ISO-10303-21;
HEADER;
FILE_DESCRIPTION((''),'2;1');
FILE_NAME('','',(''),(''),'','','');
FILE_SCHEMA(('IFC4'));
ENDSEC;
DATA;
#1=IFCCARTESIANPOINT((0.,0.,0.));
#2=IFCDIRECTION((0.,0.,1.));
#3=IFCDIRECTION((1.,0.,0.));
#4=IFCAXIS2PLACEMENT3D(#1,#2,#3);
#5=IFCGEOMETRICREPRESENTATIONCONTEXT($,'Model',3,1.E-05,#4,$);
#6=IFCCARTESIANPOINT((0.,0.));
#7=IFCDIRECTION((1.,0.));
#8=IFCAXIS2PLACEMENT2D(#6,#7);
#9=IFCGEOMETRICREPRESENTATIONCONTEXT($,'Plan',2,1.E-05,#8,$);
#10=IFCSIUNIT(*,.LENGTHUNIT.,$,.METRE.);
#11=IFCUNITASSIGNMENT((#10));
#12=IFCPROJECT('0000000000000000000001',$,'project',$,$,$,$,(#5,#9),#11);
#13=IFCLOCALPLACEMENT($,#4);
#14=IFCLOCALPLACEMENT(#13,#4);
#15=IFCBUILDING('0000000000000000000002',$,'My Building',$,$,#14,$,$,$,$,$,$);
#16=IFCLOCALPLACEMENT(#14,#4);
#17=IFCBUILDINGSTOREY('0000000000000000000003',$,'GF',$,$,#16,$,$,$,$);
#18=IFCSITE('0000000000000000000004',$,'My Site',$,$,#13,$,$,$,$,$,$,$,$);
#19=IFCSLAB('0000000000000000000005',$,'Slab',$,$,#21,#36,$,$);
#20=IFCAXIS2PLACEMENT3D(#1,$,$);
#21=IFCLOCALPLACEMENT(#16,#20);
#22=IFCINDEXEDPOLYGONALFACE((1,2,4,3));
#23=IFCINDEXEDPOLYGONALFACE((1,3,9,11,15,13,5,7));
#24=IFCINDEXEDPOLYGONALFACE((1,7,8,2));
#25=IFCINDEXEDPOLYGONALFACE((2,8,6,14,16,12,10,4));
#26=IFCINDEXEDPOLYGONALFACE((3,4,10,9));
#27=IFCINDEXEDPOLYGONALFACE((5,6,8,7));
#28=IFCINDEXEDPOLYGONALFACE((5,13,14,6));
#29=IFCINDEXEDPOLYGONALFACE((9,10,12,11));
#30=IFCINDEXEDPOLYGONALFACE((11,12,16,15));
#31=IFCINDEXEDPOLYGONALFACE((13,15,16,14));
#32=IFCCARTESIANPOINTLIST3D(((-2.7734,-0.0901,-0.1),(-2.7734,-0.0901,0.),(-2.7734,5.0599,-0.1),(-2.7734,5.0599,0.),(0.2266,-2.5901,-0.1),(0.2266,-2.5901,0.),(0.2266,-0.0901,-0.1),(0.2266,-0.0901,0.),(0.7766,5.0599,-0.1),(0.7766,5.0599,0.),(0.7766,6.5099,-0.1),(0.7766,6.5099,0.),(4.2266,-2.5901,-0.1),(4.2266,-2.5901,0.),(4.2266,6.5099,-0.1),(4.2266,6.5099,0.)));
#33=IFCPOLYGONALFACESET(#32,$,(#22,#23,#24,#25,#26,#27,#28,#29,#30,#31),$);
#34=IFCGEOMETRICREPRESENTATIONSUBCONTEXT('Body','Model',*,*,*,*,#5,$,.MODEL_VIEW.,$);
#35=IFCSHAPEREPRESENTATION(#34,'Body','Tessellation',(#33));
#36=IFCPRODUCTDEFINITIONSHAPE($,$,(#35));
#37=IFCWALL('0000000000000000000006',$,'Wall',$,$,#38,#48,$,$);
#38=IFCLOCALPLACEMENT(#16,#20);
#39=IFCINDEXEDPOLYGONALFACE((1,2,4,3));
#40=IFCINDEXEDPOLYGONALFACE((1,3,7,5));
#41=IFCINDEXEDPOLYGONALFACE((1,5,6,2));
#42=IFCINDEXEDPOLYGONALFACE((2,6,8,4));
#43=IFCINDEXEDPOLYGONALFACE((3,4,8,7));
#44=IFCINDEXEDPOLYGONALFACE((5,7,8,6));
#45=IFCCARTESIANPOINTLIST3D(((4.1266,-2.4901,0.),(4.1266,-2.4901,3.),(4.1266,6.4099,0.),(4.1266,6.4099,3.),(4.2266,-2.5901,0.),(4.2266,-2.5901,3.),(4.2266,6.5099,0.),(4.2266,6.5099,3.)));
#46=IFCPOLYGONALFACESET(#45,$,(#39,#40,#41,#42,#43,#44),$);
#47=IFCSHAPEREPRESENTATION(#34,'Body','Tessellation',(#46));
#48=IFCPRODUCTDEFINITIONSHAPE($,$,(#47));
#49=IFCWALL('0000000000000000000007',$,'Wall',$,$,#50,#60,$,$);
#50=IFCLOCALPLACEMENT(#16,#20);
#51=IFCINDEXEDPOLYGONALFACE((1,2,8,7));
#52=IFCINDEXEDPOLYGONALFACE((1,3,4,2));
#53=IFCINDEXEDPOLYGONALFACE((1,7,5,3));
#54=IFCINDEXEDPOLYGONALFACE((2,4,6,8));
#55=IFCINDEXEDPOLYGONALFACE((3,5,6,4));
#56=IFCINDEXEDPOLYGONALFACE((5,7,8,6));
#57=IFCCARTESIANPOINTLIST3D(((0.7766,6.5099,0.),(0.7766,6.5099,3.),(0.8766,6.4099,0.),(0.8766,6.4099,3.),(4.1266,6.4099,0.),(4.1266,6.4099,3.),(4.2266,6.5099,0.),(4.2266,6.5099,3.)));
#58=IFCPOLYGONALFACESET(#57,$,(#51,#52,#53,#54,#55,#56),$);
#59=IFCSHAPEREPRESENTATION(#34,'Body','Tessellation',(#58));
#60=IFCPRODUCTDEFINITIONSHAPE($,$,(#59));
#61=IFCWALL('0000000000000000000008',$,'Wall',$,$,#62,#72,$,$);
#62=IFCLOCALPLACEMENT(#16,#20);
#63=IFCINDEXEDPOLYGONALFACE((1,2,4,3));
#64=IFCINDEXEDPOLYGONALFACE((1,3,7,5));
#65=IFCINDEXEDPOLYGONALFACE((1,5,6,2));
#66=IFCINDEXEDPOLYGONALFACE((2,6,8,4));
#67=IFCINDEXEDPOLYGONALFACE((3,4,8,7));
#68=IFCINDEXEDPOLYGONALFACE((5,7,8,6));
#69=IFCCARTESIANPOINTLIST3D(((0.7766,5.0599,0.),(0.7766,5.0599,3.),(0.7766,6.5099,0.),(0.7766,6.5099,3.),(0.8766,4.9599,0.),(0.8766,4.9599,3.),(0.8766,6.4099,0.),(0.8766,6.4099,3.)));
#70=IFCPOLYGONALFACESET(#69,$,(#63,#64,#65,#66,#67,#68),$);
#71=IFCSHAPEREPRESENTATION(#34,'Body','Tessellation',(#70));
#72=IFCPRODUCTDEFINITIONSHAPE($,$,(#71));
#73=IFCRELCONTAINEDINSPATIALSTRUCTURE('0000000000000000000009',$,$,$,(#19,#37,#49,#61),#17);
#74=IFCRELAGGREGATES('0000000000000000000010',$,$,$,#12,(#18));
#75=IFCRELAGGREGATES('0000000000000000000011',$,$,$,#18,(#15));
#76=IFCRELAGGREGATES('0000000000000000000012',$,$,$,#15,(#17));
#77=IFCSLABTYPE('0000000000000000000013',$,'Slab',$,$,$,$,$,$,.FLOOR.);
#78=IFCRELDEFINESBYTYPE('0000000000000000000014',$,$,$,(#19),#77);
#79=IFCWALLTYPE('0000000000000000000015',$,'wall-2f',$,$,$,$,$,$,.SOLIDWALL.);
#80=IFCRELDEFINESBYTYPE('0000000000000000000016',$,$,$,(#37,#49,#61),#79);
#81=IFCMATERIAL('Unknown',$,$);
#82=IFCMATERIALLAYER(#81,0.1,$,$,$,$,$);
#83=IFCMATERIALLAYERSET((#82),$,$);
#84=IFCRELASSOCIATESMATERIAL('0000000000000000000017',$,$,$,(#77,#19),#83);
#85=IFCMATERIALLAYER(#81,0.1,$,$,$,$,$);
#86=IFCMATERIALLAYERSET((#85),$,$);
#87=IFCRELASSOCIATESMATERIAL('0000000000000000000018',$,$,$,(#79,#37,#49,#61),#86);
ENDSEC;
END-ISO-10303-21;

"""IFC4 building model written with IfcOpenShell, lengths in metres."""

from ifc_helpers import new_model, si_unit, frame, origin_with_axes, origin_2d_with_axis, place, context, subcontext, project, spatial, line, indexed_curve, outline, extrude, material, layer, layer_set, layer_usage, type_object, element, save


model = new_model("IFC4")

# Units and contexts
model_context = context("Model", 3, precision=1e-05, world=origin_with_axes())
plan_context = context("Plan", 2, precision=1e-05, world=origin_2d_with_axis())
body_context_1 = subcontext(model_context, "Body", "Model", "MODEL_VIEW")
ifc_project = project(units=[si_unit("LENGTHUNIT", "METRE")], contexts=[model_context, plan_context])

# Site, building, storey
site_placement = place(None, origin_with_axes())
site = spatial("IfcSite", under=ifc_project, at=site_placement, Name="My Site")
building_placement = place(site_placement, origin_with_axes())
building = spatial("IfcBuilding", under=site, at=building_placement, Name="My Building")
storey_placement = place(building_placement, origin_with_axes())
storey = spatial("IfcBuildingStorey", under=building, at=storey_placement, Name="GF")

# Slab
ifc_material = material(Name="Unknown")
ifc_layer_1 = layer(ifc_material, 0.1)
ifc_layer_set_1 = layer_set([ifc_layer_1])
ifc_layer_usage_1 = layer_usage(ifc_layer_set_1, "AXIS3", "POSITIVE", -0.1)
slab_type = type_object("IfcSlabType", Name="Slab", PredefinedType="FLOOR", material=ifc_layer_set_1)
slab_placement = place(storey_placement, frame((4.2266, -2.5901, 0.0), z_axis=(0.0, 0.0, 1.0), x_axis=(1.0, 0.0, 0.0)))
element("IfcSlab", 1, at=slab_placement, inside=storey, type_object=slab_type, material=ifc_layer_usage_1, Name="Slab", context=body_context_1, shape_type="SweptSolid", body=[
    extrude(outline(indexed_curve([(0.0, 0.0), (0.0, 9.1), (-3.45, 9.1), (-3.45, 7.65), (-7.0, 7.65), (-7.0, 2.5), (-4.0, 2.5), (-4.0, 0.0), (0.0, 0.0)])), frame((0.0, 0.0, -0.1), z_axis=(0.0, 0.0, 1.0), x_axis=(1.0, 0.0, 0.0)), (0.0, 0.0, 1.0), 0.1),
])

# Shared definitions
ifc_layer_2 = layer(ifc_material, 0.1)
ifc_layer_set_2 = layer_set([ifc_layer_2])
wall_type = type_object("IfcWallType", Name="wall-2f", PredefinedType="SOLIDWALL", material=ifc_layer_set_2)

# Walls
ifc_layer_usage_2 = layer_usage(ifc_layer_set_2, "AXIS2", "POSITIVE", 0.0)
wall_1_placement = place(storey_placement, frame((4.2266, -2.5901, 0.0), z_axis=(0.0, 0.0, 1.0), x_axis=(0.0, 1.0, 0.0)))
element("IfcWall", 2, at=wall_1_placement, inside=storey, type_object=wall_type, material=ifc_layer_usage_2, Name="Wall", context=body_context_1, shape_type="SweptSolid", body=[
    extrude(outline(indexed_curve([(0.0, 0.0), (0.1, 0.1), (9.0, 0.1), (9.1, 0.0)], segments=[line(1, 2, 3, 4, 1)])), origin_with_axes(), (0.0, 0.0, 1.0), 3.0),
])
ifc_layer_usage_3 = layer_usage(ifc_layer_set_2, "AXIS2", "POSITIVE", 0.0)
wall_2_placement = place(storey_placement, frame((4.2266, 6.5099, 0.0), z_axis=(0.0, 0.0, 1.0), x_axis=(-1.0, 0.0, 0.0)))
element("IfcWall", 3, at=wall_2_placement, inside=storey, type_object=wall_type, material=ifc_layer_usage_3, Name="Wall", context=body_context_1, shape_type="SweptSolid", body=[
    extrude(outline(indexed_curve([(0.0, 0.0), (0.1, 0.1), (3.35, 0.1), (3.45, 0.0)], segments=[line(1, 2, 3, 4, 1)])), origin_with_axes(), (0.0, 0.0, 1.0), 3.0),
])
ifc_layer_usage_4 = layer_usage(ifc_layer_set_2, "AXIS2", "POSITIVE", 0.0)
wall_3_placement = place(storey_placement, frame((0.7766, 6.5099, 0.0), z_axis=(0.0, 0.0, 1.0), x_axis=(0.0, -1.0, 0.0)))
element("IfcWall", 4, at=wall_3_placement, inside=storey, type_object=wall_type, material=ifc_layer_usage_4, Name="Wall", context=body_context_1, shape_type="SweptSolid", body=[
    extrude(outline(indexed_curve([(0.0, 0.0), (0.1, 0.1), (1.55, 0.1), (1.45, 0.0)], segments=[line(1, 2, 3, 4, 1)])), origin_with_axes(), (0.0, 0.0, 1.0), 3.0),
])

save(model, "model.ifc")
